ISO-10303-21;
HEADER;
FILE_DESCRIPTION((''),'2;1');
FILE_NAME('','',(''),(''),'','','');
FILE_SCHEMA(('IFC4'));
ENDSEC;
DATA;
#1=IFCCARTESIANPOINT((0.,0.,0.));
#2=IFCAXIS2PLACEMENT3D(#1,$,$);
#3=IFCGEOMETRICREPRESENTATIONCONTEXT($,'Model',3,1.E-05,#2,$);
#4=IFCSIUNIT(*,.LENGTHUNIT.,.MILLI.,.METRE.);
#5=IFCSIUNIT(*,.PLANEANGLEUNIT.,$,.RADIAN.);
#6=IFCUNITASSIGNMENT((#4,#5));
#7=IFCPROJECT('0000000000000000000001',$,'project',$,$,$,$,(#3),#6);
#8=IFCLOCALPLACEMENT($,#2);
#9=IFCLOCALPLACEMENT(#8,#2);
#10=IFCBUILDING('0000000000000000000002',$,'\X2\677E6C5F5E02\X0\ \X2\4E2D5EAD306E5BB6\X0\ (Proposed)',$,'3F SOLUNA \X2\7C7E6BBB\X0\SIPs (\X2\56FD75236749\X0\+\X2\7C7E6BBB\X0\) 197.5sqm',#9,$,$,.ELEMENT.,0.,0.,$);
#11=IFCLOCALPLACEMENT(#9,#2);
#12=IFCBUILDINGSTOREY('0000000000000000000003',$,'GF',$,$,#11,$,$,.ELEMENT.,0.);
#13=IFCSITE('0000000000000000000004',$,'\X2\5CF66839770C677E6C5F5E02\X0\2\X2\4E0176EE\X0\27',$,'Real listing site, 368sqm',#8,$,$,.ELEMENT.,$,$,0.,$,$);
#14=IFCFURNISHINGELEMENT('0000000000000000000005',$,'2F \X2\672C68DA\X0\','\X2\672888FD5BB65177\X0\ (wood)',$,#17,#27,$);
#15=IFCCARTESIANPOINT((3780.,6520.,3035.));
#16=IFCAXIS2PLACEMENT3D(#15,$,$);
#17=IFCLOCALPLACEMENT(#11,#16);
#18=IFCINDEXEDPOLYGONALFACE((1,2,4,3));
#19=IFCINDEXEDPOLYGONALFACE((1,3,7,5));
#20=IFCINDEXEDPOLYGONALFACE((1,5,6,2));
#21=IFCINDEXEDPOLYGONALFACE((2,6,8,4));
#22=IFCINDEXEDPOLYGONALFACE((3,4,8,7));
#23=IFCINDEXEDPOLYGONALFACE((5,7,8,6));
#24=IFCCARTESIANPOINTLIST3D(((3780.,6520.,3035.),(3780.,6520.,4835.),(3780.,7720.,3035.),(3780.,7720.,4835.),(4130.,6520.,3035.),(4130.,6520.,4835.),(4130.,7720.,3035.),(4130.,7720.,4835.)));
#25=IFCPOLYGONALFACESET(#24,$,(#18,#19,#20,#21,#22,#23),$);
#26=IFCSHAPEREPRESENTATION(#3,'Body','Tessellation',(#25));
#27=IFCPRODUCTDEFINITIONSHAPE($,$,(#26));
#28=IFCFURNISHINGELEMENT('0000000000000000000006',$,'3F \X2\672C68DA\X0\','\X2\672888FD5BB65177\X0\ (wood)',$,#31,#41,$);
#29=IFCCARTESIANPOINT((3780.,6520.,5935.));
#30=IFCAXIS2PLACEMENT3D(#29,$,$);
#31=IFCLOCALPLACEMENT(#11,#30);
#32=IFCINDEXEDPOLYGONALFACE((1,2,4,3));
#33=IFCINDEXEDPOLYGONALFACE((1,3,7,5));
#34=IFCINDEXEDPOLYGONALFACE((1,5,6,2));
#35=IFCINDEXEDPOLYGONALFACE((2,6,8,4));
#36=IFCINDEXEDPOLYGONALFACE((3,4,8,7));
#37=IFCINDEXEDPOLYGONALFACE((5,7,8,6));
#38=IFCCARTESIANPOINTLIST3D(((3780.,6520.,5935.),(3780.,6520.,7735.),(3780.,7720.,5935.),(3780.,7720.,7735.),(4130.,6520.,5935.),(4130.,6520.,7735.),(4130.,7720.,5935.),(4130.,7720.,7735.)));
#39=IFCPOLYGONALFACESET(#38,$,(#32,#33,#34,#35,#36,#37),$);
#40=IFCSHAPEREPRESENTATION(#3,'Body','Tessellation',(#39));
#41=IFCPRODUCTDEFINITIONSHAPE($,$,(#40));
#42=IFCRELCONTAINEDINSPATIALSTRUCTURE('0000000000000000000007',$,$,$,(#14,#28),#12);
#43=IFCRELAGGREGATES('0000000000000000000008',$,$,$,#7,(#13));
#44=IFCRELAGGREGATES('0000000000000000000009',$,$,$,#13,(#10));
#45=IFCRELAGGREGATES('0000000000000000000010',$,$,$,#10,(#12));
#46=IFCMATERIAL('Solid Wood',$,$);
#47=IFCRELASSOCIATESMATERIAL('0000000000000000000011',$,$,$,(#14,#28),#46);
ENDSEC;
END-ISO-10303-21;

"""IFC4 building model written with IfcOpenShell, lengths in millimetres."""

from ifc_helpers import new_model, si_unit, frame, frame_2d, origin, place, context, project, spatial, rectangle, extrude, material, element, save


model = new_model("IFC4")

# Units and contexts
model_context = context("Model", 3, precision=1e-05, world=origin())
ifc_project = project(units=[si_unit("LENGTHUNIT", "METRE", prefix="MILLI"), si_unit("PLANEANGLEUNIT", "RADIAN")], contexts=[model_context])

# Site, building, storey
site_placement = place(None, origin())
site = spatial("IfcSite", under=ifc_project, at=site_placement, Name="島根県松江市2丁目27", ObjectType="Real listing site, 368sqm", CompositionType="ELEMENT", RefElevation=0.0)
building_placement = place(site_placement, origin())
building = spatial("IfcBuilding", under=site, at=building_placement, Name="松江市 中庭の家 (Proposed)", ObjectType="3F SOLUNA 籾殻SIPs (国産杉+籾殻) 197.5sqm", CompositionType="ELEMENT", ElevationOfRefHeight=0.0, ElevationOfTerrain=0.0)
storey_placement = place(building_placement, origin())
storey = spatial("IfcBuildingStorey", under=building, at=storey_placement, Name="GF", CompositionType="ELEMENT", Elevation=0.0)

# Shared definitions
ifc_material_1 = material(Name="Solid Wood")

# Furnishing elements
furnishing_1_placement = place(storey_placement, frame((3780.0, 6520.0, 3035.0)))
element("IfcFurnishingElement", 1, at=furnishing_1_placement, inside=storey, material=ifc_material_1, Name="2F 本棚", Description="木製家具 (wood)", context=model_context, shape_type="SweptSolid", body=[
    extrude(rectangle(XDim=350.0, YDim=1200.0, at=frame_2d((175.0, 600.0))), frame((3780.0, 6520.0, 3035.0)), (0.0, 0.0, 1.0), 1800.0),
])
furnishing_2_placement = place(storey_placement, frame((3780.0, 6520.0, 5935.0)))
element("IfcFurnishingElement", 2, at=furnishing_2_placement, inside=storey, material=ifc_material_1, Name="3F 本棚", Description="木製家具 (wood)", context=model_context, shape_type="SweptSolid", body=[
    extrude(rectangle(XDim=350.0, YDim=1200.0, at=frame_2d((175.0, 600.0))), frame((3780.0, 6520.0, 5935.0)), (0.0, 0.0, 1.0), 1800.0),
])

save(model, "model.ifc")
